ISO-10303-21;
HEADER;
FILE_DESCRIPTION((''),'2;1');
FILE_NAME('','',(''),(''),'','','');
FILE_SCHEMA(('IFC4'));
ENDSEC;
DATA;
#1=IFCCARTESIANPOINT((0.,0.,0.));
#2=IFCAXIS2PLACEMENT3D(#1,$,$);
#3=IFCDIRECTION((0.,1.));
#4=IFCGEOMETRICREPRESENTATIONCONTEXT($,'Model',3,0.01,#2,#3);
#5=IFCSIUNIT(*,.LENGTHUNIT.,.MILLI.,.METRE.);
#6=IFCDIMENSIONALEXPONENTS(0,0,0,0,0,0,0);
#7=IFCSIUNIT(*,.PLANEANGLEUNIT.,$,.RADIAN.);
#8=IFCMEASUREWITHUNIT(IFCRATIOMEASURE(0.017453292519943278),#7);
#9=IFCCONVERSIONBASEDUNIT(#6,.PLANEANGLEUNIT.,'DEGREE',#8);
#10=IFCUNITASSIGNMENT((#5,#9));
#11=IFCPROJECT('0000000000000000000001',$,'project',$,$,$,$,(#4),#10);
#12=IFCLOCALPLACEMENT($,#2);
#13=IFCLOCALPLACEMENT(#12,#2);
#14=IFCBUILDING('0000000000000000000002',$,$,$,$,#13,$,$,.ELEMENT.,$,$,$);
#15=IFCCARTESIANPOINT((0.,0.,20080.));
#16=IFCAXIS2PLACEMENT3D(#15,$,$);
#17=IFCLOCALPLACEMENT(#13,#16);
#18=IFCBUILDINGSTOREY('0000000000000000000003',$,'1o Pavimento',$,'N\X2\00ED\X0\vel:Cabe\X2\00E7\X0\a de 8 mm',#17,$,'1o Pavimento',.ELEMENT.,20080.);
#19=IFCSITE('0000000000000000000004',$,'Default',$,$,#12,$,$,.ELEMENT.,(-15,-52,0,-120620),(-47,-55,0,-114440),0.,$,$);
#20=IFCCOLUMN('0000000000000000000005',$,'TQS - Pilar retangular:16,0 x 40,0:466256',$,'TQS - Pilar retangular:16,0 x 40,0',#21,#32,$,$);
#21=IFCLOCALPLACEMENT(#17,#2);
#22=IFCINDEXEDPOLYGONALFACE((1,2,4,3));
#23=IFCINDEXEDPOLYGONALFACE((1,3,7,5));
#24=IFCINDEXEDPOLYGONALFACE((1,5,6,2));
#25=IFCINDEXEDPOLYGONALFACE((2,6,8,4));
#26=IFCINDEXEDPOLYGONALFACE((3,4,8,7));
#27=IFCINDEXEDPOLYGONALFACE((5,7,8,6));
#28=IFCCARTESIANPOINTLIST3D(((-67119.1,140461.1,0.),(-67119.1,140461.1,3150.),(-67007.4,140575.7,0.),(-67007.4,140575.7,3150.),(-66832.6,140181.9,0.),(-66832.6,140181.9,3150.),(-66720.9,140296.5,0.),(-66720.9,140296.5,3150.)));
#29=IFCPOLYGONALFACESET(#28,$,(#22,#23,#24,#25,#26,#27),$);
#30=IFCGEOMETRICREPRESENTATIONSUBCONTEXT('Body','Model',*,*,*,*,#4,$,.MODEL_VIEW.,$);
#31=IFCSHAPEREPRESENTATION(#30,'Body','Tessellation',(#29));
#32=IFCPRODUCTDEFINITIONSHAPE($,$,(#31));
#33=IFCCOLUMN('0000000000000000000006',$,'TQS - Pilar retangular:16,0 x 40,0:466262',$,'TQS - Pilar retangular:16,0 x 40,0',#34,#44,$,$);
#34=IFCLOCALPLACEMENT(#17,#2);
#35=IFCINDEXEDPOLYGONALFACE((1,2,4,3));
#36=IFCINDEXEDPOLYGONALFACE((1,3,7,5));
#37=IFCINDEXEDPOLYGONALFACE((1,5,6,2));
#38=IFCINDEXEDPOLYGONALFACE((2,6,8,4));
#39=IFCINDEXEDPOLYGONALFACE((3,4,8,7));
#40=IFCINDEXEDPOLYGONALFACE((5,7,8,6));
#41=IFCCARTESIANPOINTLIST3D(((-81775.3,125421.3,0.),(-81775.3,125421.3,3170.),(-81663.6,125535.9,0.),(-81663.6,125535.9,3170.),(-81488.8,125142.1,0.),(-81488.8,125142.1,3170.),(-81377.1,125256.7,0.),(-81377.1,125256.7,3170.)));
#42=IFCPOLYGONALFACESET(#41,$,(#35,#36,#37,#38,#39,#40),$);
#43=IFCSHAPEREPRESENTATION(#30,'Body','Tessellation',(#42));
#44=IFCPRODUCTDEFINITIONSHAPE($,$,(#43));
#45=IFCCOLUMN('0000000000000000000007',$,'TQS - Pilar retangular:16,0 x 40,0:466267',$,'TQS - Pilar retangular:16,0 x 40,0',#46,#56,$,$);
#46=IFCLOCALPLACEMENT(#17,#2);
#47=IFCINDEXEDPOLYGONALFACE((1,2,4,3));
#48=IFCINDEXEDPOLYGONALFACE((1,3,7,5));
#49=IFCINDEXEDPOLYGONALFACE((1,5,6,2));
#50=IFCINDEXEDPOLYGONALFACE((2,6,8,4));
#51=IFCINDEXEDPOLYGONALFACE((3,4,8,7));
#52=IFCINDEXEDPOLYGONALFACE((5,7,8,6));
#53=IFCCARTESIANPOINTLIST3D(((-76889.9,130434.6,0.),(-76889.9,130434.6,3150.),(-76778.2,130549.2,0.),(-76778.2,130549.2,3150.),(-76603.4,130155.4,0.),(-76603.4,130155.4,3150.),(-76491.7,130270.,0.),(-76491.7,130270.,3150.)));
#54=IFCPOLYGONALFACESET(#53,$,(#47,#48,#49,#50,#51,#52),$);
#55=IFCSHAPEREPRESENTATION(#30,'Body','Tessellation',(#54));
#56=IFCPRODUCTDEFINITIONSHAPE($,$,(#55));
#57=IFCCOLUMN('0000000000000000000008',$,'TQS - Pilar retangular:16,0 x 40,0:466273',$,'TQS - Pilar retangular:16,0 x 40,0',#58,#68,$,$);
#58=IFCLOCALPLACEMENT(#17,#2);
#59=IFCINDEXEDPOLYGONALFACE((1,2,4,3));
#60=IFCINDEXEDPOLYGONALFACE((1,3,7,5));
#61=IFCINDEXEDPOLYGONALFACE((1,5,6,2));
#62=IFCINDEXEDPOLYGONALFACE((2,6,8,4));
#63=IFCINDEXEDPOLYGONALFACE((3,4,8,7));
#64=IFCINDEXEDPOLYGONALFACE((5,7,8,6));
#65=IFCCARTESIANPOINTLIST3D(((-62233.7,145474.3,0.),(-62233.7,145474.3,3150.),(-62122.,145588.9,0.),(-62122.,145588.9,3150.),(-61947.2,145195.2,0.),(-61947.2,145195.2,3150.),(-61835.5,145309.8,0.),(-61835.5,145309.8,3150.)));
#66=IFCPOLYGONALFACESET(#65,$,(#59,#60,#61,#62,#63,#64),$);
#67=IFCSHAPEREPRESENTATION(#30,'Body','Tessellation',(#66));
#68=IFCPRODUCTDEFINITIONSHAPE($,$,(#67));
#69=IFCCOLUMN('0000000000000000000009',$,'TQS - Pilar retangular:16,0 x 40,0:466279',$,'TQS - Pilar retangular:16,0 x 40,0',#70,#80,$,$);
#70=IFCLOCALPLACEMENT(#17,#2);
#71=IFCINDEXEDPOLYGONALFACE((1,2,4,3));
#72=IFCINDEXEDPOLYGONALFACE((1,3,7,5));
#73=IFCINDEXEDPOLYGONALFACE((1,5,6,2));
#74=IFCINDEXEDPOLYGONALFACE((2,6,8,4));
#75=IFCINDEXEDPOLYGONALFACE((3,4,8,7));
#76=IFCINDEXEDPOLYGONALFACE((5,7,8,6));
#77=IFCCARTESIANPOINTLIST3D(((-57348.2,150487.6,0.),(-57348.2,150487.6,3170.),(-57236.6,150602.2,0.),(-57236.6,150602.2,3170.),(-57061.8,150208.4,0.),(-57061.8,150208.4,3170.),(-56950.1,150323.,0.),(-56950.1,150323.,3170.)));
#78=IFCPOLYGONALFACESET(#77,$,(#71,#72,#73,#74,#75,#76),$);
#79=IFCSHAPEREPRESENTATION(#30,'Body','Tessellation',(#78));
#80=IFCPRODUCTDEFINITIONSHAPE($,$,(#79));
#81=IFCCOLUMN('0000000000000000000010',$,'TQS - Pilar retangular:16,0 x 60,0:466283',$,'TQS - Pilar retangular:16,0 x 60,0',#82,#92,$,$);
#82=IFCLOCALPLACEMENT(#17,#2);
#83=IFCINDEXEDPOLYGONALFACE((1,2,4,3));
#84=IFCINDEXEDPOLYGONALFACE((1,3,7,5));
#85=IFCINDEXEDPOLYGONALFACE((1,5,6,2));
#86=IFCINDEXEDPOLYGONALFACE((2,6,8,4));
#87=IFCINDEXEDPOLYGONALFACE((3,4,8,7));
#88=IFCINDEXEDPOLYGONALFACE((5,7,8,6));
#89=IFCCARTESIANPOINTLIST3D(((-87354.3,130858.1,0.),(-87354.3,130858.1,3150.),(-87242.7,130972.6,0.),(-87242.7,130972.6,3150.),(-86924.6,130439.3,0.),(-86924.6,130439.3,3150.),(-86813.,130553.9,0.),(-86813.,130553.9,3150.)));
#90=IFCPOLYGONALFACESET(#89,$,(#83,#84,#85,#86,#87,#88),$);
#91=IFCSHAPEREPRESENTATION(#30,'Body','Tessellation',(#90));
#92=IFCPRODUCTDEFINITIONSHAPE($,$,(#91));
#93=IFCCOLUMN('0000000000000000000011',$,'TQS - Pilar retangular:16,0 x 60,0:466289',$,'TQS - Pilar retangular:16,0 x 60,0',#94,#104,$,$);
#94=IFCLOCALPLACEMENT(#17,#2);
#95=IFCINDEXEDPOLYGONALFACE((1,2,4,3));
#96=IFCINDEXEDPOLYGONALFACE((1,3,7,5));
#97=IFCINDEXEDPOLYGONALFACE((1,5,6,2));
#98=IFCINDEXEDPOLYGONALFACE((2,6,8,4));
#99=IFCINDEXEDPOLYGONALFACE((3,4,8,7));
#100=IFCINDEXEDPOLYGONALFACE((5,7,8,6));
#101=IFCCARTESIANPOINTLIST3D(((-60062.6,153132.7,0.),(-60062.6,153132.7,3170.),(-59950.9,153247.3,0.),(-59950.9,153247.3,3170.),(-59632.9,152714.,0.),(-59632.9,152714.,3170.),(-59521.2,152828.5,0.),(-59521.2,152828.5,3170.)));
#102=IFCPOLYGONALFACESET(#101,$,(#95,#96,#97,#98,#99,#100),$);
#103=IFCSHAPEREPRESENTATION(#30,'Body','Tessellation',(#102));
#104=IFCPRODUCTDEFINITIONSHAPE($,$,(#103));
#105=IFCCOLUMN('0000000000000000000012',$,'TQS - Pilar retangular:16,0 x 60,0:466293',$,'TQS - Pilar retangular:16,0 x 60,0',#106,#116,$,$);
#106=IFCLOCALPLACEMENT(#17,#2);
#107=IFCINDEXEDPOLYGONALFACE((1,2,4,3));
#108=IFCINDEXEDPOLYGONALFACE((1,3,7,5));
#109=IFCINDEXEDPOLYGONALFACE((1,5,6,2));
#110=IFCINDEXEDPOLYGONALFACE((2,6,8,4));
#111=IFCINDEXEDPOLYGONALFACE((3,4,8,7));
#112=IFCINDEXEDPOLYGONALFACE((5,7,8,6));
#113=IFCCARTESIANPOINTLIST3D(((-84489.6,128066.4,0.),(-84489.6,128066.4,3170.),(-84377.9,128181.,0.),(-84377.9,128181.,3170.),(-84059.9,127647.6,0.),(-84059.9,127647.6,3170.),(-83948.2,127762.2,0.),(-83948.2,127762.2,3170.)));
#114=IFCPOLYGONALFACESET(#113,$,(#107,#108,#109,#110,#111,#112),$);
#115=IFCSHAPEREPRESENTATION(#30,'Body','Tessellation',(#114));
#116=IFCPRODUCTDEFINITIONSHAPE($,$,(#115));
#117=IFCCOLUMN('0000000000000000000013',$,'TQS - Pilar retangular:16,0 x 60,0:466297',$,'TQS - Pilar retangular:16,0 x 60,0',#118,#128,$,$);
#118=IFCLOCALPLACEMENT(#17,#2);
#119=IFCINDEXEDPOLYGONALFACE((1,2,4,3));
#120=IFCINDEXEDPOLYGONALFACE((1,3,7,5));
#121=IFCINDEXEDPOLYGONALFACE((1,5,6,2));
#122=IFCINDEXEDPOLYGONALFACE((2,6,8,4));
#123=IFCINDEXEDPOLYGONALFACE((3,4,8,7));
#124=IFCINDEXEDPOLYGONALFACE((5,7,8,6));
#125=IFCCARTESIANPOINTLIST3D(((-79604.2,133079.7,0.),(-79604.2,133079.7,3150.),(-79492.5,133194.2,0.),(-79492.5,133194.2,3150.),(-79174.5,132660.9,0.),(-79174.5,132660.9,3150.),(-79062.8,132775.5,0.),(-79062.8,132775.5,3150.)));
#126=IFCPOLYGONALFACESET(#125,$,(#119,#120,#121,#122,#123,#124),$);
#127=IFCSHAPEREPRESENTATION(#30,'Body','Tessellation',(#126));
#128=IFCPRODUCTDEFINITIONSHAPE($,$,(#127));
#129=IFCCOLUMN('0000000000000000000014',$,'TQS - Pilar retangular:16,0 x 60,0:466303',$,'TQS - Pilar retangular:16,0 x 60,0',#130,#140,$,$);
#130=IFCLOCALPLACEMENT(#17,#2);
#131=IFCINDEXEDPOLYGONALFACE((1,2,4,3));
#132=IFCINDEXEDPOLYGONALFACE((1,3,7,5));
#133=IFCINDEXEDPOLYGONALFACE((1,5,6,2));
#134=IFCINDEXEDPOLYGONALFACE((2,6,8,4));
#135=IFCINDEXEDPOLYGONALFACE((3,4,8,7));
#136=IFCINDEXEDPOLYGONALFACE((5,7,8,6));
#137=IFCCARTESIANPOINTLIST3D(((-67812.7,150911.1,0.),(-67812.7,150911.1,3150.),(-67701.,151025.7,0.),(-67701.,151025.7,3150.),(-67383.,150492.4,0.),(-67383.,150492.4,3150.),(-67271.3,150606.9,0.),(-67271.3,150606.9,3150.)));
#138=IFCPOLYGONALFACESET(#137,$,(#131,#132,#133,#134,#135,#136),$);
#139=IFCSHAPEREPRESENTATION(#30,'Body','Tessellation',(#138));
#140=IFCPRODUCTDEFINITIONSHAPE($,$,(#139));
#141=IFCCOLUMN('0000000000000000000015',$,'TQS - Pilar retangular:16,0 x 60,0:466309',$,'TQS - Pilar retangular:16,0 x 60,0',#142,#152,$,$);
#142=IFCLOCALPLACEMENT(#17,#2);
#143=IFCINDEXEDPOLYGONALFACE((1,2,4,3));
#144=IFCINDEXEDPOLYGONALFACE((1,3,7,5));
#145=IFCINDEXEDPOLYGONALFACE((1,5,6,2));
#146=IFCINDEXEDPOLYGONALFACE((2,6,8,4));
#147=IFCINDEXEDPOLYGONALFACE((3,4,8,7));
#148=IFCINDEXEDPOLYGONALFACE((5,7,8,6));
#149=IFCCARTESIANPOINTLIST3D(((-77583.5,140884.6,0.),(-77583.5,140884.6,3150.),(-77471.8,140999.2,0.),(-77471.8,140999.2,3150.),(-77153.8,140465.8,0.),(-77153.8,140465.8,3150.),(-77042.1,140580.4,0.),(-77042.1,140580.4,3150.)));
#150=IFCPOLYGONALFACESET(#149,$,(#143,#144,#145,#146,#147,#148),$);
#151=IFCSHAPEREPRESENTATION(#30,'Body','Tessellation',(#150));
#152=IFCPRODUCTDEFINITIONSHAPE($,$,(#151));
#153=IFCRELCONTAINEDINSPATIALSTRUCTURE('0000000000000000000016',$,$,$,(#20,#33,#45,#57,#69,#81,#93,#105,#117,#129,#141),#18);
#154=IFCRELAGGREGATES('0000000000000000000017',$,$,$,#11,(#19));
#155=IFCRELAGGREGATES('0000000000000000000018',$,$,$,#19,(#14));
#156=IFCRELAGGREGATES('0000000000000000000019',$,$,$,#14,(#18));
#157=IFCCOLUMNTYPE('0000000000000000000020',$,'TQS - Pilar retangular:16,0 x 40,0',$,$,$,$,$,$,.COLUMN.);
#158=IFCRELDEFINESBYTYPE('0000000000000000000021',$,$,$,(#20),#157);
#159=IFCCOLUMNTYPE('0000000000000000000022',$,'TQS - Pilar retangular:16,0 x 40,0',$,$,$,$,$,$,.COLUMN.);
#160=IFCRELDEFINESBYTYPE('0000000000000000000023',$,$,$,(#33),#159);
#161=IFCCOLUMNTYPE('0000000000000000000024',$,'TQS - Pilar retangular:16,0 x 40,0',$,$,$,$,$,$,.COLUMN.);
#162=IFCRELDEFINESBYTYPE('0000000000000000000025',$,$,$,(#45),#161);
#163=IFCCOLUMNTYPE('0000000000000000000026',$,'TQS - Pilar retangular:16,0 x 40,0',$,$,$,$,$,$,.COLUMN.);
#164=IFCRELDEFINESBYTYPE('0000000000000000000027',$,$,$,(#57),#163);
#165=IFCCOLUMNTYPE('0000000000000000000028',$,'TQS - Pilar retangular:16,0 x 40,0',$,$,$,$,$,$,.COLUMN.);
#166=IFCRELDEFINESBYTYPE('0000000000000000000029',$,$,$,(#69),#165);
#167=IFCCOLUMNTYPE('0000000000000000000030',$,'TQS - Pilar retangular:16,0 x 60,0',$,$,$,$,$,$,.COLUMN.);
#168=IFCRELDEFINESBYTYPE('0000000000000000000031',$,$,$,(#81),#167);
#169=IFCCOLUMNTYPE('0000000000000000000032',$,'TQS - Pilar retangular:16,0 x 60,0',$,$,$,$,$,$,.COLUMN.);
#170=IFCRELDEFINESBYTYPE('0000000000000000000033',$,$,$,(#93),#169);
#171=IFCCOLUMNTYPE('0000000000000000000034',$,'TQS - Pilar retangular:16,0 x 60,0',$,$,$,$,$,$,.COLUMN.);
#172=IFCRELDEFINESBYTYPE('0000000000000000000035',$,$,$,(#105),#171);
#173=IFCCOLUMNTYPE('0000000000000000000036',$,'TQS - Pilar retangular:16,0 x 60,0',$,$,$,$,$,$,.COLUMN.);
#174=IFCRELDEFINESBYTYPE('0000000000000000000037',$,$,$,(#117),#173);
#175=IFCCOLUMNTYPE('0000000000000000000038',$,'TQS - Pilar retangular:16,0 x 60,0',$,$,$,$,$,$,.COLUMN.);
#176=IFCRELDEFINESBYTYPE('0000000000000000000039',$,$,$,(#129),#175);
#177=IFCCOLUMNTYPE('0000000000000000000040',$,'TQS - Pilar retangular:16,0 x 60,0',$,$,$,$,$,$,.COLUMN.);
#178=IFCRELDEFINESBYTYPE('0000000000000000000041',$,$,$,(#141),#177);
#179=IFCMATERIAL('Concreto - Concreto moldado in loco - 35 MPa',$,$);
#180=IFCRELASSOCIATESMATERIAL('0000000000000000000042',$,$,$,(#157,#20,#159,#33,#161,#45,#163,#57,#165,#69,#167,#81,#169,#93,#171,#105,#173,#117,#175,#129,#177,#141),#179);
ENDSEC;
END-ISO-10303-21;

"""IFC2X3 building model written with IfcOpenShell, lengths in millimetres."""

from ifc_helpers import new_model, entity, si_unit, converted_unit, direction, frame, frame_2d, origin, place, context, subcontext, project, spatial, rectangle, extrude, source, transform, mapped, material, type_object, type_shapes, element, save


model = new_model("IFC2X3")

# Units and contexts
model_context = context("Model", 3, precision=0.01, world=origin(), true_north=direction((0.0, 1.0)))
body_context = subcontext(model_context, "Body", "Model", "MODEL_VIEW")
ifc_project = project(units=[si_unit("LENGTHUNIT", "METRE", prefix="MILLI"), converted_unit("PLANEANGLEUNIT", "DEGREE", entity("IfcRatioMeasure", 0.017453292519943278), si_unit("PLANEANGLEUNIT", "RADIAN"), dimensions=[0, 0, 0, 0, 0, 0, 0])], contexts=[model_context])

# Site, building, storey
site_placement = place(None, origin())
site = spatial("IfcSite", under=ifc_project, at=site_placement, Name="Default", CompositionType="ELEMENT", RefLatitude=(-15, -52, 0, -120620), RefLongitude=(-47, -55, 0, -114440), RefElevation=0.0)
building_placement = place(site_placement, origin())
building = spatial("IfcBuilding", under=site, at=building_placement, CompositionType="ELEMENT")
storey_placement = place(building_placement, frame((0.0, 0.0, 20080.0)))
storey = spatial("IfcBuildingStorey", under=building, at=storey_placement, Name="1o Pavimento", ObjectType="Nível:Cabeça de 8 mm", LongName="1o Pavimento", CompositionType="ELEMENT", Elevation=20080.0)

# Columns
ifc_material = material(Name="Concreto - Concreto moldado in loco - 35 MPa")
column_type_1 = type_object("IfcColumnType", Name="TQS - Pilar retangular:16,0 x 40,0", PredefinedType="COLUMN", material=ifc_material)
shared_shape_1 = source(origin(), body_context, "Body", "SweptSolid", [
    extrude(rectangle(XDim=400.0, YDim=160.0, at=frame_2d((0.0, 0.0), x_axis=(1.0, 0.0))), frame((-66920.0, 140378.8, 20080.0), z_axis=(0.0, 0.0, 1.0), x_axis=(-0.71618, 0.697915, 0.0)), (0.0, 0.0, 1.0), 3150.0),
])
type_shapes(column_type_1, [shared_shape_1])
column_1_placement = place(storey_placement, frame((0.0, 0.0, -20080.0)))
element("IfcColumn", 1, at=column_1_placement, inside=storey, type_object=column_type_1, material=ifc_material, Name="TQS - Pilar retangular:16,0 x 40,0:466256", ObjectType="TQS - Pilar retangular:16,0 x 40,0", context=body_context, shape_type="MappedRepresentation", body=[
    mapped(shared_shape_1, transform((0.0, 0.0, 0.0), scale=1.0)),
])
column_type_2 = type_object("IfcColumnType", Name="TQS - Pilar retangular:16,0 x 40,0", PredefinedType="COLUMN", material=ifc_material)
shared_shape_2 = source(origin(), body_context, "Body", "SweptSolid", [
    extrude(rectangle(XDim=400.0, YDim=160.0, at=frame_2d((0.0, 0.0), x_axis=(1.0, 0.0))), frame((-81576.2, 125339.0, 20080.0), z_axis=(0.0, 0.0, 1.0), x_axis=(-0.71618, 0.697915, 0.0)), (0.0, 0.0, 1.0), 3170.0),
])
type_shapes(column_type_2, [shared_shape_2])
column_2_placement = place(storey_placement, frame((0.0, 0.0, -20080.0)))
element("IfcColumn", 2, at=column_2_placement, inside=storey, type_object=column_type_2, material=ifc_material, Name="TQS - Pilar retangular:16,0 x 40,0:466262", ObjectType="TQS - Pilar retangular:16,0 x 40,0", context=body_context, shape_type="MappedRepresentation", body=[
    mapped(shared_shape_2, transform((0.0, 0.0, 0.0), scale=1.0)),
])
column_type_3 = type_object("IfcColumnType", Name="TQS - Pilar retangular:16,0 x 40,0", PredefinedType="COLUMN", material=ifc_material)
shared_shape_3 = source(origin(), body_context, "Body", "SweptSolid", [
    extrude(rectangle(XDim=400.0, YDim=160.0, at=frame_2d((0.0, 0.0), x_axis=(1.0, 0.0))), frame((-76690.8, 130352.3, 20080.0), z_axis=(0.0, 0.0, 1.0), x_axis=(-0.71618, 0.697915, 0.0)), (0.0, 0.0, 1.0), 3150.0),
])
type_shapes(column_type_3, [shared_shape_3])
column_3_placement = place(storey_placement, frame((0.0, 0.0, -20080.0)))
element("IfcColumn", 3, at=column_3_placement, inside=storey, type_object=column_type_3, material=ifc_material, Name="TQS - Pilar retangular:16,0 x 40,0:466267", ObjectType="TQS - Pilar retangular:16,0 x 40,0", context=body_context, shape_type="MappedRepresentation", body=[
    mapped(shared_shape_3, transform((0.0, 0.0, 0.0), scale=1.0)),
])
column_type_4 = type_object("IfcColumnType", Name="TQS - Pilar retangular:16,0 x 40,0", PredefinedType="COLUMN", material=ifc_material)
shared_shape_4 = source(origin(), body_context, "Body", "SweptSolid", [
    extrude(rectangle(XDim=400.0, YDim=160.0, at=frame_2d((0.0, 0.0), x_axis=(1.0, 0.0))), frame((-62034.6, 145392.1, 20080.0), z_axis=(0.0, 0.0, 1.0), x_axis=(-0.71618, 0.697915, 0.0)), (0.0, 0.0, 1.0), 3150.0),
])
type_shapes(column_type_4, [shared_shape_4])
column_4_placement = place(storey_placement, frame((0.0, 0.0, -20080.0)))
element("IfcColumn", 4, at=column_4_placement, inside=storey, type_object=column_type_4, material=ifc_material, Name="TQS - Pilar retangular:16,0 x 40,0:466273", ObjectType="TQS - Pilar retangular:16,0 x 40,0", context=body_context, shape_type="MappedRepresentation", body=[
    mapped(shared_shape_4, transform((0.0, 0.0, 0.0), scale=1.0)),
])
column_type_5 = type_object("IfcColumnType", Name="TQS - Pilar retangular:16,0 x 40,0", PredefinedType="COLUMN", material=ifc_material)
shared_shape_5 = source(origin(), body_context, "Body", "SweptSolid", [
    extrude(rectangle(XDim=400.0, YDim=160.0, at=frame_2d((0.0, 0.0), x_axis=(1.0, 0.0))), frame((-57149.2, 150405.3, 20080.0), z_axis=(0.0, 0.0, 1.0), x_axis=(-0.71618, 0.697915, 0.0)), (0.0, 0.0, 1.0), 3170.0),
])
type_shapes(column_type_5, [shared_shape_5])
column_5_placement = place(storey_placement, frame((0.0, 0.0, -20080.0)))
element("IfcColumn", 5, at=column_5_placement, inside=storey, type_object=column_type_5, material=ifc_material, Name="TQS - Pilar retangular:16,0 x 40,0:466279", ObjectType="TQS - Pilar retangular:16,0 x 40,0", context=body_context, shape_type="MappedRepresentation", body=[
    mapped(shared_shape_5, transform((0.0, 0.0, 0.0), scale=1.0)),
])
column_type_6 = type_object("IfcColumnType", Name="TQS - Pilar retangular:16,0 x 60,0", PredefinedType="COLUMN", material=ifc_material)
shared_shape_6 = source(origin(), body_context, "Body", "SweptSolid", [
    extrude(rectangle(XDim=600.0, YDim=160.0, at=frame_2d((0.0, 0.0), x_axis=(1.0, 0.0))), frame((-87083.6, 130706.0, 20080.0), z_axis=(0.0, 0.0, 1.0), x_axis=(-0.71618, 0.697915, 0.0)), (0.0, 0.0, 1.0), 3150.0),
])
type_shapes(column_type_6, [shared_shape_6])
column_6_placement = place(storey_placement, frame((0.0, 0.0, -20080.0)))
element("IfcColumn", 6, at=column_6_placement, inside=storey, type_object=column_type_6, material=ifc_material, Name="TQS - Pilar retangular:16,0 x 60,0:466283", ObjectType="TQS - Pilar retangular:16,0 x 60,0", context=body_context, shape_type="MappedRepresentation", body=[
    mapped(shared_shape_6, transform((0.0, 0.0, 0.0), scale=1.0)),
])
column_type_7 = type_object("IfcColumnType", Name="TQS - Pilar retangular:16,0 x 60,0", PredefinedType="COLUMN", material=ifc_material)
shared_shape_7 = source(origin(), body_context, "Body", "SweptSolid", [
    extrude(rectangle(XDim=600.0, YDim=160.0, at=frame_2d((0.0, 0.0), x_axis=(1.0, 0.0))), frame((-59791.9, 152980.6, 20080.0), z_axis=(0.0, 0.0, 1.0), x_axis=(-0.71618, 0.697915, 0.0)), (0.0, 0.0, 1.0), 3170.0),
])
type_shapes(column_type_7, [shared_shape_7])
column_7_placement = place(storey_placement, frame((0.0, 0.0, -20080.0)))
element("IfcColumn", 7, at=column_7_placement, inside=storey, type_object=column_type_7, material=ifc_material, Name="TQS - Pilar retangular:16,0 x 60,0:466289", ObjectType="TQS - Pilar retangular:16,0 x 60,0", context=body_context, shape_type="MappedRepresentation", body=[
    mapped(shared_shape_7, transform((0.0, 0.0, 0.0), scale=1.0)),
])
column_type_8 = type_object("IfcColumnType", Name="TQS - Pilar retangular:16,0 x 60,0", PredefinedType="COLUMN", material=ifc_material)
shared_shape_8 = source(origin(), body_context, "Body", "SweptSolid", [
    extrude(rectangle(XDim=600.0, YDim=160.0, at=frame_2d((0.0, 0.0), x_axis=(1.0, 0.0))), frame((-84218.9, 127914.3, 20080.0), z_axis=(0.0, 0.0, 1.0), x_axis=(-0.71618, 0.697915, 0.0)), (0.0, 0.0, 1.0), 3170.0),
])
type_shapes(column_type_8, [shared_shape_8])
column_8_placement = place(storey_placement, frame((0.0, 0.0, -20080.0)))
element("IfcColumn", 8, at=column_8_placement, inside=storey, type_object=column_type_8, material=ifc_material, Name="TQS - Pilar retangular:16,0 x 60,0:466293", ObjectType="TQS - Pilar retangular:16,0 x 60,0", context=body_context, shape_type="MappedRepresentation", body=[
    mapped(shared_shape_8, transform((0.0, 0.0, 0.0), scale=1.0)),
])
column_type_9 = type_object("IfcColumnType", Name="TQS - Pilar retangular:16,0 x 60,0", PredefinedType="COLUMN", material=ifc_material)
shared_shape_9 = source(origin(), body_context, "Body", "SweptSolid", [
    extrude(rectangle(XDim=600.0, YDim=160.0, at=frame_2d((0.0, 0.0), x_axis=(1.0, 0.0))), frame((-79333.5, 132927.6, 20080.0), z_axis=(0.0, 0.0, 1.0), x_axis=(-0.71618, 0.697915, 0.0)), (0.0, 0.0, 1.0), 3150.0),
])
type_shapes(column_type_9, [shared_shape_9])
column_9_placement = place(storey_placement, frame((0.0, 0.0, -20080.0)))
element("IfcColumn", 9, at=column_9_placement, inside=storey, type_object=column_type_9, material=ifc_material, Name="TQS - Pilar retangular:16,0 x 60,0:466297", ObjectType="TQS - Pilar retangular:16,0 x 60,0", context=body_context, shape_type="MappedRepresentation", body=[
    mapped(shared_shape_9, transform((0.0, 0.0, 0.0), scale=1.0)),
])
column_type_10 = type_object("IfcColumnType", Name="TQS - Pilar retangular:16,0 x 60,0", PredefinedType="COLUMN", material=ifc_material)
shared_shape_10 = source(origin(), body_context, "Body", "SweptSolid", [
    extrude(rectangle(XDim=600.0, YDim=160.0, at=frame_2d((0.0, 0.0), x_axis=(1.0, 0.0))), frame((-67542.0, 150759.0, 20080.0), z_axis=(0.0, 0.0, 1.0), x_axis=(-0.71618, 0.697915, 0.0)), (0.0, 0.0, 1.0), 3150.0),
])
type_shapes(column_type_10, [shared_shape_10])
column_10_placement = place(storey_placement, frame((0.0, 0.0, -20080.0)))
element("IfcColumn", 10, at=column_10_placement, inside=storey, type_object=column_type_10, material=ifc_material, Name="TQS - Pilar retangular:16,0 x 60,0:466303", ObjectType="TQS - Pilar retangular:16,0 x 60,0", context=body_context, shape_type="MappedRepresentation", body=[
    mapped(shared_shape_10, transform((0.0, 0.0, 0.0), scale=1.0)),
])
column_type_11 = type_object("IfcColumnType", Name="TQS - Pilar retangular:16,0 x 60,0", PredefinedType="COLUMN", material=ifc_material)
shared_shape_11 = source(origin(), body_context, "Body", "SweptSolid", [
    extrude(rectangle(XDim=600.0, YDim=160.0, at=frame_2d((0.0, 0.0), x_axis=(1.0, 0.0))), frame((-77312.8, 140732.5, 20080.0), z_axis=(0.0, 0.0, 1.0), x_axis=(-0.71618, 0.697915, 0.0)), (0.0, 0.0, 1.0), 3150.0),
])
type_shapes(column_type_11, [shared_shape_11])
column_11_placement = place(storey_placement, frame((0.0, 0.0, -20080.0)))
element("IfcColumn", 11, at=column_11_placement, inside=storey, type_object=column_type_11, material=ifc_material, Name="TQS - Pilar retangular:16,0 x 60,0:466309", ObjectType="TQS - Pilar retangular:16,0 x 60,0", context=body_context, shape_type="MappedRepresentation", body=[
    mapped(shared_shape_11, transform((0.0, 0.0, 0.0), scale=1.0)),
])

save(model, "model.ifc")
